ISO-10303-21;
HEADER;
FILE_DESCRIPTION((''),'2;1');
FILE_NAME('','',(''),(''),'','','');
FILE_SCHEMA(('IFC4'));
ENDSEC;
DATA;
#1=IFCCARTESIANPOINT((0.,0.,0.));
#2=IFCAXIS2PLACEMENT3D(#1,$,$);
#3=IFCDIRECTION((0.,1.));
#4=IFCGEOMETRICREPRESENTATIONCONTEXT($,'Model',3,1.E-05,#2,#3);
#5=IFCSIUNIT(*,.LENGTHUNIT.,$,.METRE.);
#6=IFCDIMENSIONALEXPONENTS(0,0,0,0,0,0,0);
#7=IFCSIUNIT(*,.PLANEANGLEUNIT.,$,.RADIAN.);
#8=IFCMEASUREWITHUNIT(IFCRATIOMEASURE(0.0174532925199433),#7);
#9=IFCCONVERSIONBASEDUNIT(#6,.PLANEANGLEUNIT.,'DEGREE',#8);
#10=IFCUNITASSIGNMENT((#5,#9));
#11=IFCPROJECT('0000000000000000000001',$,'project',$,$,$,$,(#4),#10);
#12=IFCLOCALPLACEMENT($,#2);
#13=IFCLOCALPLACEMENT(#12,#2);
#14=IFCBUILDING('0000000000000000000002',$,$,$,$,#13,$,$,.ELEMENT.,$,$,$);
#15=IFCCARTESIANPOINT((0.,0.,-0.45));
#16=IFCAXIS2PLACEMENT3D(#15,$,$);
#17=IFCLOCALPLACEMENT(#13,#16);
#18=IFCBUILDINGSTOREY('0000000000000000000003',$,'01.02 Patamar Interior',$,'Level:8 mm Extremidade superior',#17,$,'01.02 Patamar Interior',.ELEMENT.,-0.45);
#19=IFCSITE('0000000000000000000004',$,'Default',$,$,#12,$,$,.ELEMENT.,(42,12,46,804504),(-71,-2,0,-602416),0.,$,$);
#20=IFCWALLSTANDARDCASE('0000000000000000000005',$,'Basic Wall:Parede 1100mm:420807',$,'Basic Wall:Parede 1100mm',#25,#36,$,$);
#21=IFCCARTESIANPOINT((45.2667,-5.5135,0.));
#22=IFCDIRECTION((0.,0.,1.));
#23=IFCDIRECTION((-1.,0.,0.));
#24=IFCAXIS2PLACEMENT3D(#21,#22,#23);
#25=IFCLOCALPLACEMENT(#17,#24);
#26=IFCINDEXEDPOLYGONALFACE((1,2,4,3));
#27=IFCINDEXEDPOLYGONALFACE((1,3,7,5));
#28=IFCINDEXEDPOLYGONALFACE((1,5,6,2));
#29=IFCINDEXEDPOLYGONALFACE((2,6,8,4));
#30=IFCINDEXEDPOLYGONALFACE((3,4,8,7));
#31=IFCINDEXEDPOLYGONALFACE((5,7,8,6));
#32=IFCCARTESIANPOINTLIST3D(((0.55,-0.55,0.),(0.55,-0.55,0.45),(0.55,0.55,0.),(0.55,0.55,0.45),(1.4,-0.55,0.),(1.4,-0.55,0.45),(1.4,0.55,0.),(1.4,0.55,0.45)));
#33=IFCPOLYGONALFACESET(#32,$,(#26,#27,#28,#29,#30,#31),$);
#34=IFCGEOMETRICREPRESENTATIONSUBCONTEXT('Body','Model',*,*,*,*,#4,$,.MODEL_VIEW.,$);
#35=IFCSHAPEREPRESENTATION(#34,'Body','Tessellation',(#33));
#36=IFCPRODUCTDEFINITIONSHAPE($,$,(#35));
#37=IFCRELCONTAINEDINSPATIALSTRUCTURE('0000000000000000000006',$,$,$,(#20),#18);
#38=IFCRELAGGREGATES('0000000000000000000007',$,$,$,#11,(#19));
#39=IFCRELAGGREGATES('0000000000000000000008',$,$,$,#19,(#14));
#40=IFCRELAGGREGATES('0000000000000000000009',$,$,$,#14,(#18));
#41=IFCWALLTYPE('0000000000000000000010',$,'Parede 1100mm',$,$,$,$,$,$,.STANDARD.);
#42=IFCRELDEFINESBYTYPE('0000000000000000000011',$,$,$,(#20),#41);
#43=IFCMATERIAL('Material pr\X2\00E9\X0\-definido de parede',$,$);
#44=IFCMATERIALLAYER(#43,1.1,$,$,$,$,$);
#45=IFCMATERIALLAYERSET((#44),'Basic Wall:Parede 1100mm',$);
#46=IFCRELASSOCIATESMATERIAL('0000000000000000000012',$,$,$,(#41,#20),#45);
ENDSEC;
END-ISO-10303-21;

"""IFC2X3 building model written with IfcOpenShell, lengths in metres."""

from ifc_helpers import new_model, entity, si_unit, converted_unit, direction, frame, frame_2d, origin, place, context, subcontext, project, spatial, rectangle, extrude, clip, halfspace, material, layer, layer_set, layer_usage, type_object, element, save


model = new_model("IFC2X3")

# Units and contexts
model_context = context("Model", 3, precision=1e-05, world=origin(), true_north=direction((0.0, 1.0)))
body_context = subcontext(model_context, "Body", "Model", "MODEL_VIEW")
ifc_project = project(units=[si_unit("LENGTHUNIT", "METRE"), converted_unit("PLANEANGLEUNIT", "DEGREE", entity("IfcRatioMeasure", 0.0174532925199433), si_unit("PLANEANGLEUNIT", "RADIAN"), dimensions=[0, 0, 0, 0, 0, 0, 0])], contexts=[model_context])

# Site, building, storey
site_placement = place(None, origin())
site = spatial("IfcSite", under=ifc_project, at=site_placement, Name="Default", CompositionType="ELEMENT", RefLatitude=(42, 12, 46, 804504), RefLongitude=(-71, -2, 0, -602416), RefElevation=0.0)
building_placement = place(site_placement, origin())
building = spatial("IfcBuilding", under=site, at=building_placement, CompositionType="ELEMENT")
storey_placement = place(building_placement, frame((0.0, 0.0, -0.45)))
storey = spatial("IfcBuildingStorey", under=building, at=storey_placement, Name="01.02 Patamar Interior", ObjectType="Level:8 mm Extremidade superior", LongName="01.02 Patamar Interior", CompositionType="ELEMENT", Elevation=-0.45)

# Wall
ifc_material_1 = material(Name="Material pré-definido de parede")
ifc_layer_1 = layer(ifc_material_1, 1.1)
ifc_layer_set_1 = layer_set([ifc_layer_1], Name="Basic Wall:Parede 1100mm")
wall_type_1 = type_object("IfcWallType", Name="Parede 1100mm", PredefinedType="STANDARD", material=ifc_layer_set_1)
ifc_layer_usage_1 = layer_usage(ifc_layer_set_1, "AXIS2", "NEGATIVE", 0.55)
wall_1_placement = place(storey_placement, frame((45.2667, -5.5135, 0.0), z_axis=(0.0, 0.0, 1.0), x_axis=(-1.0, 0.0, 0.0)))
element("IfcWallStandardCase", 1, at=wall_1_placement, inside=storey, type_object=wall_type_1, material=ifc_layer_usage_1, Name="Basic Wall:Parede 1100mm:420807", ObjectType="Basic Wall:Parede 1100mm", context=body_context, shape_type="Clipping", body=[
    clip(extrude(rectangle(XDim=0.85, YDim=1.1, at=frame_2d((0.975, 0.0), x_axis=(-1.0, 0.0))), origin(), (0.0, 0.0, 1.0), 0.45), halfspace(frame((0.0, 0.0, -2.4)), True)),
])

save(model, "model.ifc")
